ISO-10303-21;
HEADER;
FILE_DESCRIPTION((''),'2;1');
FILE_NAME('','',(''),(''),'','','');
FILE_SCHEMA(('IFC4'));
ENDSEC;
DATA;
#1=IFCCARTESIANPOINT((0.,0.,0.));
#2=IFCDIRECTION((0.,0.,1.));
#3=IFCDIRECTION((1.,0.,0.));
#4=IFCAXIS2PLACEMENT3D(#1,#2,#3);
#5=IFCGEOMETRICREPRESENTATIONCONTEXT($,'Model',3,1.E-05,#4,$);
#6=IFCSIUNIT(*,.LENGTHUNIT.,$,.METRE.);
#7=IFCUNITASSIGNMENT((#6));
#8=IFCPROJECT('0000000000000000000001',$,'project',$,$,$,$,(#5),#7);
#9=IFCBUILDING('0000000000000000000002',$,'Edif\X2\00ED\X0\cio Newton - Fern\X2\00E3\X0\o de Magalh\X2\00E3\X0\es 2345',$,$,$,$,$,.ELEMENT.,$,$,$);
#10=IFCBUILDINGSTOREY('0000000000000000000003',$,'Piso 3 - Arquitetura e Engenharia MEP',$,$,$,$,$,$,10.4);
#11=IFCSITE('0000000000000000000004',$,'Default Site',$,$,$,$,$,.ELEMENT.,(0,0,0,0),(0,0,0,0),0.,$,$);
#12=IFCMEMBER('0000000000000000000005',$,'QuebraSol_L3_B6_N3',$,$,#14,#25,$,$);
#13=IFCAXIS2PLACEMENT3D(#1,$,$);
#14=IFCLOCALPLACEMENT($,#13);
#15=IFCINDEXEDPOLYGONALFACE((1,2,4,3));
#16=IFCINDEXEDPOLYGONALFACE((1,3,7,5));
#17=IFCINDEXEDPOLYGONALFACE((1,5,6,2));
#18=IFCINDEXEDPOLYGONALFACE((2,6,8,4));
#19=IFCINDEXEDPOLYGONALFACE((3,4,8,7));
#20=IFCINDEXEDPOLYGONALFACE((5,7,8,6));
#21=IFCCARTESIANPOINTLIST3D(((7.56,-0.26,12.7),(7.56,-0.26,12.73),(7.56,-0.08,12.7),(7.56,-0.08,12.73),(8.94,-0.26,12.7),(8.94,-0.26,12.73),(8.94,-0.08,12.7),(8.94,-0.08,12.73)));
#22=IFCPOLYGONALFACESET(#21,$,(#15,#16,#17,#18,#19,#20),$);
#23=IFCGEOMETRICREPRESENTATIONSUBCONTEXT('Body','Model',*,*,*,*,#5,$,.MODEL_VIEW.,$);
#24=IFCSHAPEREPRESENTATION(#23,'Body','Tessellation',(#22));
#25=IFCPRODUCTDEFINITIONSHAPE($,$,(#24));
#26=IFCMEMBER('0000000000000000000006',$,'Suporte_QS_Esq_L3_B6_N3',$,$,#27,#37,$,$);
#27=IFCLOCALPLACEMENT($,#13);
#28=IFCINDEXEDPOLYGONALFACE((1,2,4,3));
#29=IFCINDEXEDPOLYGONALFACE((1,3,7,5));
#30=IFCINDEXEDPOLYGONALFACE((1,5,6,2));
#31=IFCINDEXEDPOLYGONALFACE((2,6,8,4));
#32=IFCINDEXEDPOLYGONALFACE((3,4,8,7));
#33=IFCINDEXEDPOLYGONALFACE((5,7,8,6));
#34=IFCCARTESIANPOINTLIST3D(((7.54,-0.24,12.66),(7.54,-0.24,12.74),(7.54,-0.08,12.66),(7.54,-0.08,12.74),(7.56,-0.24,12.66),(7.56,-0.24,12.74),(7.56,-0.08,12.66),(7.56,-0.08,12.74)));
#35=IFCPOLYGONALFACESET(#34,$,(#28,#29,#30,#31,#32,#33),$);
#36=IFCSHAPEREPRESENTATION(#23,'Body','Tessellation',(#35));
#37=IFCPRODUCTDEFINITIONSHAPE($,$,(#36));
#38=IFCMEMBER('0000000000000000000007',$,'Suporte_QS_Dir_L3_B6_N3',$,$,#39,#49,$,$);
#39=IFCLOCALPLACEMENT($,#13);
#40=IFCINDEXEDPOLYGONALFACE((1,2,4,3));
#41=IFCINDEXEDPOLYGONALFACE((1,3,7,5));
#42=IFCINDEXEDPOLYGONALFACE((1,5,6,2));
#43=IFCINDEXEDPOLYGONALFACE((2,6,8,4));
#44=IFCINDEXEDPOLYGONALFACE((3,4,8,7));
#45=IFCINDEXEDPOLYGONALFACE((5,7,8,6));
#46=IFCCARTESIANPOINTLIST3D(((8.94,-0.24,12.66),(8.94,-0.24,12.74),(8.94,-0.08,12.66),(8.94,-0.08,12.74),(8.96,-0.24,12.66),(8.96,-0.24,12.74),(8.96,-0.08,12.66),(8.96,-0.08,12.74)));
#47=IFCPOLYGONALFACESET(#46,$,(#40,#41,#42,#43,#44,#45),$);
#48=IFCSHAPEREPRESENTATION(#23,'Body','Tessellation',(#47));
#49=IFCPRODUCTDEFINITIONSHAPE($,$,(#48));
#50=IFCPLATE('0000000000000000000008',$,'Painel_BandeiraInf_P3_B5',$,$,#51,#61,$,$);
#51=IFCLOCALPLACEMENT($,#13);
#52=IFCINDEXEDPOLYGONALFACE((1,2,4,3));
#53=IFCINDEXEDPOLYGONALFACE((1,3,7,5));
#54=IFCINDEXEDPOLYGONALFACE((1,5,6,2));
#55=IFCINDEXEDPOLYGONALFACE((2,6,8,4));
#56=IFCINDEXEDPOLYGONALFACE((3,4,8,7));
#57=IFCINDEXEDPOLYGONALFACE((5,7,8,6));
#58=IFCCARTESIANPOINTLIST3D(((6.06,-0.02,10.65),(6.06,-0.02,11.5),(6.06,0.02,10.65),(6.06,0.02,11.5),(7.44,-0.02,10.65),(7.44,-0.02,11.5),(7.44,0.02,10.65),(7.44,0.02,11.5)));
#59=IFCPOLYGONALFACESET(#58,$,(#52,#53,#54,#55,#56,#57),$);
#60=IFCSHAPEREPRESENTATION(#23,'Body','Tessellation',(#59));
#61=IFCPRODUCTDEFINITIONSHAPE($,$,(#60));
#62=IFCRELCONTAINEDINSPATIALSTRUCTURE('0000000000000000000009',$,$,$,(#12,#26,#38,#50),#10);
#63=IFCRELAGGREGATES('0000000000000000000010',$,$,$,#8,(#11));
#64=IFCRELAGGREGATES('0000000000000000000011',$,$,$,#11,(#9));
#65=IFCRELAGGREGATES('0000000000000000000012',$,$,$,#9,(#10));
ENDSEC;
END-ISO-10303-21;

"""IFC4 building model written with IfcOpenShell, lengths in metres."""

from ifc_helpers import new_model, si_unit, frame, frame_2d, origin_with_axes, place, context, subcontext, project, spatial, rectangle, extrude, element, save


model = new_model("IFC4")

# Units and contexts
model_context = context("Model", 3, precision=1e-05, world=origin_with_axes())
body_context = subcontext(model_context, "Body", "Model", "MODEL_VIEW")
ifc_project = project(units=[si_unit("LENGTHUNIT", "METRE")], contexts=[model_context])

# Site, building, storey
site = spatial("IfcSite", under=ifc_project, Name="Default Site", CompositionType="ELEMENT", RefLatitude=(0, 0, 0, 0), RefLongitude=(0, 0, 0, 0), RefElevation=0.0)
building = spatial("IfcBuilding", under=site, Name="Edifício Newton - Fernão de Magalhães 2345", CompositionType="ELEMENT")
storey = spatial("IfcBuildingStorey", under=building, Name="Piso 3 - Arquitetura e Engenharia MEP", Elevation=10.4)

# Members
member_1_placement = place(None, frame((7.56, -0.26, 12.7), z_axis=(0.0, 0.0, 1.0), x_axis=(1.0, 0.0, 0.0)))
element("IfcMember", 1, at=member_1_placement, inside=storey, Name="QuebraSol_L3_B6_N3", context=body_context, shape_type="SweptSolid", body=[
    extrude(rectangle(XDim=1.38, YDim=0.18, at=frame_2d((0.69, 0.09))), origin_with_axes(), (0.0, 0.0, 1.0), 0.03),
])
for number, where, z_axis, x_axis, name in (
    (2, (7.54, -0.24, 12.66), (0.0, 0.0, 1.0), (1.0, 0.0, 0.0), "Suporte_QS_Esq_L3_B6_N3"),
    (3, (8.94, -0.24, 12.66), (0.0, 0.0, 1.0), (1.0, 0.0, 0.0), "Suporte_QS_Dir_L3_B6_N3"),
):
    element("IfcMember", number, at=place(None, frame(where, z_axis=z_axis, x_axis=x_axis)), inside=storey, Name=name, context=body_context, shape_type="SweptSolid", body=[
        extrude(rectangle(XDim=0.02, YDim=0.16, at=frame_2d((0.01, 0.08))), origin_with_axes(), (0.0, 0.0, 1.0), 0.08),
    ])

# Plate
plate_placement = place(None, frame((6.06, -0.02, 10.65), z_axis=(0.0, 0.0, 1.0), x_axis=(1.0, 0.0, 0.0)))
element("IfcPlate", 4, at=plate_placement, inside=storey, Name="Painel_BandeiraInf_P3_B5", context=body_context, shape_type="SweptSolid", body=[
    extrude(rectangle(XDim=1.38, YDim=0.04, at=frame_2d((0.69, 0.02))), origin_with_axes(), (0.0, 0.0, 1.0), 0.85),
])

save(model, "model.ifc")
